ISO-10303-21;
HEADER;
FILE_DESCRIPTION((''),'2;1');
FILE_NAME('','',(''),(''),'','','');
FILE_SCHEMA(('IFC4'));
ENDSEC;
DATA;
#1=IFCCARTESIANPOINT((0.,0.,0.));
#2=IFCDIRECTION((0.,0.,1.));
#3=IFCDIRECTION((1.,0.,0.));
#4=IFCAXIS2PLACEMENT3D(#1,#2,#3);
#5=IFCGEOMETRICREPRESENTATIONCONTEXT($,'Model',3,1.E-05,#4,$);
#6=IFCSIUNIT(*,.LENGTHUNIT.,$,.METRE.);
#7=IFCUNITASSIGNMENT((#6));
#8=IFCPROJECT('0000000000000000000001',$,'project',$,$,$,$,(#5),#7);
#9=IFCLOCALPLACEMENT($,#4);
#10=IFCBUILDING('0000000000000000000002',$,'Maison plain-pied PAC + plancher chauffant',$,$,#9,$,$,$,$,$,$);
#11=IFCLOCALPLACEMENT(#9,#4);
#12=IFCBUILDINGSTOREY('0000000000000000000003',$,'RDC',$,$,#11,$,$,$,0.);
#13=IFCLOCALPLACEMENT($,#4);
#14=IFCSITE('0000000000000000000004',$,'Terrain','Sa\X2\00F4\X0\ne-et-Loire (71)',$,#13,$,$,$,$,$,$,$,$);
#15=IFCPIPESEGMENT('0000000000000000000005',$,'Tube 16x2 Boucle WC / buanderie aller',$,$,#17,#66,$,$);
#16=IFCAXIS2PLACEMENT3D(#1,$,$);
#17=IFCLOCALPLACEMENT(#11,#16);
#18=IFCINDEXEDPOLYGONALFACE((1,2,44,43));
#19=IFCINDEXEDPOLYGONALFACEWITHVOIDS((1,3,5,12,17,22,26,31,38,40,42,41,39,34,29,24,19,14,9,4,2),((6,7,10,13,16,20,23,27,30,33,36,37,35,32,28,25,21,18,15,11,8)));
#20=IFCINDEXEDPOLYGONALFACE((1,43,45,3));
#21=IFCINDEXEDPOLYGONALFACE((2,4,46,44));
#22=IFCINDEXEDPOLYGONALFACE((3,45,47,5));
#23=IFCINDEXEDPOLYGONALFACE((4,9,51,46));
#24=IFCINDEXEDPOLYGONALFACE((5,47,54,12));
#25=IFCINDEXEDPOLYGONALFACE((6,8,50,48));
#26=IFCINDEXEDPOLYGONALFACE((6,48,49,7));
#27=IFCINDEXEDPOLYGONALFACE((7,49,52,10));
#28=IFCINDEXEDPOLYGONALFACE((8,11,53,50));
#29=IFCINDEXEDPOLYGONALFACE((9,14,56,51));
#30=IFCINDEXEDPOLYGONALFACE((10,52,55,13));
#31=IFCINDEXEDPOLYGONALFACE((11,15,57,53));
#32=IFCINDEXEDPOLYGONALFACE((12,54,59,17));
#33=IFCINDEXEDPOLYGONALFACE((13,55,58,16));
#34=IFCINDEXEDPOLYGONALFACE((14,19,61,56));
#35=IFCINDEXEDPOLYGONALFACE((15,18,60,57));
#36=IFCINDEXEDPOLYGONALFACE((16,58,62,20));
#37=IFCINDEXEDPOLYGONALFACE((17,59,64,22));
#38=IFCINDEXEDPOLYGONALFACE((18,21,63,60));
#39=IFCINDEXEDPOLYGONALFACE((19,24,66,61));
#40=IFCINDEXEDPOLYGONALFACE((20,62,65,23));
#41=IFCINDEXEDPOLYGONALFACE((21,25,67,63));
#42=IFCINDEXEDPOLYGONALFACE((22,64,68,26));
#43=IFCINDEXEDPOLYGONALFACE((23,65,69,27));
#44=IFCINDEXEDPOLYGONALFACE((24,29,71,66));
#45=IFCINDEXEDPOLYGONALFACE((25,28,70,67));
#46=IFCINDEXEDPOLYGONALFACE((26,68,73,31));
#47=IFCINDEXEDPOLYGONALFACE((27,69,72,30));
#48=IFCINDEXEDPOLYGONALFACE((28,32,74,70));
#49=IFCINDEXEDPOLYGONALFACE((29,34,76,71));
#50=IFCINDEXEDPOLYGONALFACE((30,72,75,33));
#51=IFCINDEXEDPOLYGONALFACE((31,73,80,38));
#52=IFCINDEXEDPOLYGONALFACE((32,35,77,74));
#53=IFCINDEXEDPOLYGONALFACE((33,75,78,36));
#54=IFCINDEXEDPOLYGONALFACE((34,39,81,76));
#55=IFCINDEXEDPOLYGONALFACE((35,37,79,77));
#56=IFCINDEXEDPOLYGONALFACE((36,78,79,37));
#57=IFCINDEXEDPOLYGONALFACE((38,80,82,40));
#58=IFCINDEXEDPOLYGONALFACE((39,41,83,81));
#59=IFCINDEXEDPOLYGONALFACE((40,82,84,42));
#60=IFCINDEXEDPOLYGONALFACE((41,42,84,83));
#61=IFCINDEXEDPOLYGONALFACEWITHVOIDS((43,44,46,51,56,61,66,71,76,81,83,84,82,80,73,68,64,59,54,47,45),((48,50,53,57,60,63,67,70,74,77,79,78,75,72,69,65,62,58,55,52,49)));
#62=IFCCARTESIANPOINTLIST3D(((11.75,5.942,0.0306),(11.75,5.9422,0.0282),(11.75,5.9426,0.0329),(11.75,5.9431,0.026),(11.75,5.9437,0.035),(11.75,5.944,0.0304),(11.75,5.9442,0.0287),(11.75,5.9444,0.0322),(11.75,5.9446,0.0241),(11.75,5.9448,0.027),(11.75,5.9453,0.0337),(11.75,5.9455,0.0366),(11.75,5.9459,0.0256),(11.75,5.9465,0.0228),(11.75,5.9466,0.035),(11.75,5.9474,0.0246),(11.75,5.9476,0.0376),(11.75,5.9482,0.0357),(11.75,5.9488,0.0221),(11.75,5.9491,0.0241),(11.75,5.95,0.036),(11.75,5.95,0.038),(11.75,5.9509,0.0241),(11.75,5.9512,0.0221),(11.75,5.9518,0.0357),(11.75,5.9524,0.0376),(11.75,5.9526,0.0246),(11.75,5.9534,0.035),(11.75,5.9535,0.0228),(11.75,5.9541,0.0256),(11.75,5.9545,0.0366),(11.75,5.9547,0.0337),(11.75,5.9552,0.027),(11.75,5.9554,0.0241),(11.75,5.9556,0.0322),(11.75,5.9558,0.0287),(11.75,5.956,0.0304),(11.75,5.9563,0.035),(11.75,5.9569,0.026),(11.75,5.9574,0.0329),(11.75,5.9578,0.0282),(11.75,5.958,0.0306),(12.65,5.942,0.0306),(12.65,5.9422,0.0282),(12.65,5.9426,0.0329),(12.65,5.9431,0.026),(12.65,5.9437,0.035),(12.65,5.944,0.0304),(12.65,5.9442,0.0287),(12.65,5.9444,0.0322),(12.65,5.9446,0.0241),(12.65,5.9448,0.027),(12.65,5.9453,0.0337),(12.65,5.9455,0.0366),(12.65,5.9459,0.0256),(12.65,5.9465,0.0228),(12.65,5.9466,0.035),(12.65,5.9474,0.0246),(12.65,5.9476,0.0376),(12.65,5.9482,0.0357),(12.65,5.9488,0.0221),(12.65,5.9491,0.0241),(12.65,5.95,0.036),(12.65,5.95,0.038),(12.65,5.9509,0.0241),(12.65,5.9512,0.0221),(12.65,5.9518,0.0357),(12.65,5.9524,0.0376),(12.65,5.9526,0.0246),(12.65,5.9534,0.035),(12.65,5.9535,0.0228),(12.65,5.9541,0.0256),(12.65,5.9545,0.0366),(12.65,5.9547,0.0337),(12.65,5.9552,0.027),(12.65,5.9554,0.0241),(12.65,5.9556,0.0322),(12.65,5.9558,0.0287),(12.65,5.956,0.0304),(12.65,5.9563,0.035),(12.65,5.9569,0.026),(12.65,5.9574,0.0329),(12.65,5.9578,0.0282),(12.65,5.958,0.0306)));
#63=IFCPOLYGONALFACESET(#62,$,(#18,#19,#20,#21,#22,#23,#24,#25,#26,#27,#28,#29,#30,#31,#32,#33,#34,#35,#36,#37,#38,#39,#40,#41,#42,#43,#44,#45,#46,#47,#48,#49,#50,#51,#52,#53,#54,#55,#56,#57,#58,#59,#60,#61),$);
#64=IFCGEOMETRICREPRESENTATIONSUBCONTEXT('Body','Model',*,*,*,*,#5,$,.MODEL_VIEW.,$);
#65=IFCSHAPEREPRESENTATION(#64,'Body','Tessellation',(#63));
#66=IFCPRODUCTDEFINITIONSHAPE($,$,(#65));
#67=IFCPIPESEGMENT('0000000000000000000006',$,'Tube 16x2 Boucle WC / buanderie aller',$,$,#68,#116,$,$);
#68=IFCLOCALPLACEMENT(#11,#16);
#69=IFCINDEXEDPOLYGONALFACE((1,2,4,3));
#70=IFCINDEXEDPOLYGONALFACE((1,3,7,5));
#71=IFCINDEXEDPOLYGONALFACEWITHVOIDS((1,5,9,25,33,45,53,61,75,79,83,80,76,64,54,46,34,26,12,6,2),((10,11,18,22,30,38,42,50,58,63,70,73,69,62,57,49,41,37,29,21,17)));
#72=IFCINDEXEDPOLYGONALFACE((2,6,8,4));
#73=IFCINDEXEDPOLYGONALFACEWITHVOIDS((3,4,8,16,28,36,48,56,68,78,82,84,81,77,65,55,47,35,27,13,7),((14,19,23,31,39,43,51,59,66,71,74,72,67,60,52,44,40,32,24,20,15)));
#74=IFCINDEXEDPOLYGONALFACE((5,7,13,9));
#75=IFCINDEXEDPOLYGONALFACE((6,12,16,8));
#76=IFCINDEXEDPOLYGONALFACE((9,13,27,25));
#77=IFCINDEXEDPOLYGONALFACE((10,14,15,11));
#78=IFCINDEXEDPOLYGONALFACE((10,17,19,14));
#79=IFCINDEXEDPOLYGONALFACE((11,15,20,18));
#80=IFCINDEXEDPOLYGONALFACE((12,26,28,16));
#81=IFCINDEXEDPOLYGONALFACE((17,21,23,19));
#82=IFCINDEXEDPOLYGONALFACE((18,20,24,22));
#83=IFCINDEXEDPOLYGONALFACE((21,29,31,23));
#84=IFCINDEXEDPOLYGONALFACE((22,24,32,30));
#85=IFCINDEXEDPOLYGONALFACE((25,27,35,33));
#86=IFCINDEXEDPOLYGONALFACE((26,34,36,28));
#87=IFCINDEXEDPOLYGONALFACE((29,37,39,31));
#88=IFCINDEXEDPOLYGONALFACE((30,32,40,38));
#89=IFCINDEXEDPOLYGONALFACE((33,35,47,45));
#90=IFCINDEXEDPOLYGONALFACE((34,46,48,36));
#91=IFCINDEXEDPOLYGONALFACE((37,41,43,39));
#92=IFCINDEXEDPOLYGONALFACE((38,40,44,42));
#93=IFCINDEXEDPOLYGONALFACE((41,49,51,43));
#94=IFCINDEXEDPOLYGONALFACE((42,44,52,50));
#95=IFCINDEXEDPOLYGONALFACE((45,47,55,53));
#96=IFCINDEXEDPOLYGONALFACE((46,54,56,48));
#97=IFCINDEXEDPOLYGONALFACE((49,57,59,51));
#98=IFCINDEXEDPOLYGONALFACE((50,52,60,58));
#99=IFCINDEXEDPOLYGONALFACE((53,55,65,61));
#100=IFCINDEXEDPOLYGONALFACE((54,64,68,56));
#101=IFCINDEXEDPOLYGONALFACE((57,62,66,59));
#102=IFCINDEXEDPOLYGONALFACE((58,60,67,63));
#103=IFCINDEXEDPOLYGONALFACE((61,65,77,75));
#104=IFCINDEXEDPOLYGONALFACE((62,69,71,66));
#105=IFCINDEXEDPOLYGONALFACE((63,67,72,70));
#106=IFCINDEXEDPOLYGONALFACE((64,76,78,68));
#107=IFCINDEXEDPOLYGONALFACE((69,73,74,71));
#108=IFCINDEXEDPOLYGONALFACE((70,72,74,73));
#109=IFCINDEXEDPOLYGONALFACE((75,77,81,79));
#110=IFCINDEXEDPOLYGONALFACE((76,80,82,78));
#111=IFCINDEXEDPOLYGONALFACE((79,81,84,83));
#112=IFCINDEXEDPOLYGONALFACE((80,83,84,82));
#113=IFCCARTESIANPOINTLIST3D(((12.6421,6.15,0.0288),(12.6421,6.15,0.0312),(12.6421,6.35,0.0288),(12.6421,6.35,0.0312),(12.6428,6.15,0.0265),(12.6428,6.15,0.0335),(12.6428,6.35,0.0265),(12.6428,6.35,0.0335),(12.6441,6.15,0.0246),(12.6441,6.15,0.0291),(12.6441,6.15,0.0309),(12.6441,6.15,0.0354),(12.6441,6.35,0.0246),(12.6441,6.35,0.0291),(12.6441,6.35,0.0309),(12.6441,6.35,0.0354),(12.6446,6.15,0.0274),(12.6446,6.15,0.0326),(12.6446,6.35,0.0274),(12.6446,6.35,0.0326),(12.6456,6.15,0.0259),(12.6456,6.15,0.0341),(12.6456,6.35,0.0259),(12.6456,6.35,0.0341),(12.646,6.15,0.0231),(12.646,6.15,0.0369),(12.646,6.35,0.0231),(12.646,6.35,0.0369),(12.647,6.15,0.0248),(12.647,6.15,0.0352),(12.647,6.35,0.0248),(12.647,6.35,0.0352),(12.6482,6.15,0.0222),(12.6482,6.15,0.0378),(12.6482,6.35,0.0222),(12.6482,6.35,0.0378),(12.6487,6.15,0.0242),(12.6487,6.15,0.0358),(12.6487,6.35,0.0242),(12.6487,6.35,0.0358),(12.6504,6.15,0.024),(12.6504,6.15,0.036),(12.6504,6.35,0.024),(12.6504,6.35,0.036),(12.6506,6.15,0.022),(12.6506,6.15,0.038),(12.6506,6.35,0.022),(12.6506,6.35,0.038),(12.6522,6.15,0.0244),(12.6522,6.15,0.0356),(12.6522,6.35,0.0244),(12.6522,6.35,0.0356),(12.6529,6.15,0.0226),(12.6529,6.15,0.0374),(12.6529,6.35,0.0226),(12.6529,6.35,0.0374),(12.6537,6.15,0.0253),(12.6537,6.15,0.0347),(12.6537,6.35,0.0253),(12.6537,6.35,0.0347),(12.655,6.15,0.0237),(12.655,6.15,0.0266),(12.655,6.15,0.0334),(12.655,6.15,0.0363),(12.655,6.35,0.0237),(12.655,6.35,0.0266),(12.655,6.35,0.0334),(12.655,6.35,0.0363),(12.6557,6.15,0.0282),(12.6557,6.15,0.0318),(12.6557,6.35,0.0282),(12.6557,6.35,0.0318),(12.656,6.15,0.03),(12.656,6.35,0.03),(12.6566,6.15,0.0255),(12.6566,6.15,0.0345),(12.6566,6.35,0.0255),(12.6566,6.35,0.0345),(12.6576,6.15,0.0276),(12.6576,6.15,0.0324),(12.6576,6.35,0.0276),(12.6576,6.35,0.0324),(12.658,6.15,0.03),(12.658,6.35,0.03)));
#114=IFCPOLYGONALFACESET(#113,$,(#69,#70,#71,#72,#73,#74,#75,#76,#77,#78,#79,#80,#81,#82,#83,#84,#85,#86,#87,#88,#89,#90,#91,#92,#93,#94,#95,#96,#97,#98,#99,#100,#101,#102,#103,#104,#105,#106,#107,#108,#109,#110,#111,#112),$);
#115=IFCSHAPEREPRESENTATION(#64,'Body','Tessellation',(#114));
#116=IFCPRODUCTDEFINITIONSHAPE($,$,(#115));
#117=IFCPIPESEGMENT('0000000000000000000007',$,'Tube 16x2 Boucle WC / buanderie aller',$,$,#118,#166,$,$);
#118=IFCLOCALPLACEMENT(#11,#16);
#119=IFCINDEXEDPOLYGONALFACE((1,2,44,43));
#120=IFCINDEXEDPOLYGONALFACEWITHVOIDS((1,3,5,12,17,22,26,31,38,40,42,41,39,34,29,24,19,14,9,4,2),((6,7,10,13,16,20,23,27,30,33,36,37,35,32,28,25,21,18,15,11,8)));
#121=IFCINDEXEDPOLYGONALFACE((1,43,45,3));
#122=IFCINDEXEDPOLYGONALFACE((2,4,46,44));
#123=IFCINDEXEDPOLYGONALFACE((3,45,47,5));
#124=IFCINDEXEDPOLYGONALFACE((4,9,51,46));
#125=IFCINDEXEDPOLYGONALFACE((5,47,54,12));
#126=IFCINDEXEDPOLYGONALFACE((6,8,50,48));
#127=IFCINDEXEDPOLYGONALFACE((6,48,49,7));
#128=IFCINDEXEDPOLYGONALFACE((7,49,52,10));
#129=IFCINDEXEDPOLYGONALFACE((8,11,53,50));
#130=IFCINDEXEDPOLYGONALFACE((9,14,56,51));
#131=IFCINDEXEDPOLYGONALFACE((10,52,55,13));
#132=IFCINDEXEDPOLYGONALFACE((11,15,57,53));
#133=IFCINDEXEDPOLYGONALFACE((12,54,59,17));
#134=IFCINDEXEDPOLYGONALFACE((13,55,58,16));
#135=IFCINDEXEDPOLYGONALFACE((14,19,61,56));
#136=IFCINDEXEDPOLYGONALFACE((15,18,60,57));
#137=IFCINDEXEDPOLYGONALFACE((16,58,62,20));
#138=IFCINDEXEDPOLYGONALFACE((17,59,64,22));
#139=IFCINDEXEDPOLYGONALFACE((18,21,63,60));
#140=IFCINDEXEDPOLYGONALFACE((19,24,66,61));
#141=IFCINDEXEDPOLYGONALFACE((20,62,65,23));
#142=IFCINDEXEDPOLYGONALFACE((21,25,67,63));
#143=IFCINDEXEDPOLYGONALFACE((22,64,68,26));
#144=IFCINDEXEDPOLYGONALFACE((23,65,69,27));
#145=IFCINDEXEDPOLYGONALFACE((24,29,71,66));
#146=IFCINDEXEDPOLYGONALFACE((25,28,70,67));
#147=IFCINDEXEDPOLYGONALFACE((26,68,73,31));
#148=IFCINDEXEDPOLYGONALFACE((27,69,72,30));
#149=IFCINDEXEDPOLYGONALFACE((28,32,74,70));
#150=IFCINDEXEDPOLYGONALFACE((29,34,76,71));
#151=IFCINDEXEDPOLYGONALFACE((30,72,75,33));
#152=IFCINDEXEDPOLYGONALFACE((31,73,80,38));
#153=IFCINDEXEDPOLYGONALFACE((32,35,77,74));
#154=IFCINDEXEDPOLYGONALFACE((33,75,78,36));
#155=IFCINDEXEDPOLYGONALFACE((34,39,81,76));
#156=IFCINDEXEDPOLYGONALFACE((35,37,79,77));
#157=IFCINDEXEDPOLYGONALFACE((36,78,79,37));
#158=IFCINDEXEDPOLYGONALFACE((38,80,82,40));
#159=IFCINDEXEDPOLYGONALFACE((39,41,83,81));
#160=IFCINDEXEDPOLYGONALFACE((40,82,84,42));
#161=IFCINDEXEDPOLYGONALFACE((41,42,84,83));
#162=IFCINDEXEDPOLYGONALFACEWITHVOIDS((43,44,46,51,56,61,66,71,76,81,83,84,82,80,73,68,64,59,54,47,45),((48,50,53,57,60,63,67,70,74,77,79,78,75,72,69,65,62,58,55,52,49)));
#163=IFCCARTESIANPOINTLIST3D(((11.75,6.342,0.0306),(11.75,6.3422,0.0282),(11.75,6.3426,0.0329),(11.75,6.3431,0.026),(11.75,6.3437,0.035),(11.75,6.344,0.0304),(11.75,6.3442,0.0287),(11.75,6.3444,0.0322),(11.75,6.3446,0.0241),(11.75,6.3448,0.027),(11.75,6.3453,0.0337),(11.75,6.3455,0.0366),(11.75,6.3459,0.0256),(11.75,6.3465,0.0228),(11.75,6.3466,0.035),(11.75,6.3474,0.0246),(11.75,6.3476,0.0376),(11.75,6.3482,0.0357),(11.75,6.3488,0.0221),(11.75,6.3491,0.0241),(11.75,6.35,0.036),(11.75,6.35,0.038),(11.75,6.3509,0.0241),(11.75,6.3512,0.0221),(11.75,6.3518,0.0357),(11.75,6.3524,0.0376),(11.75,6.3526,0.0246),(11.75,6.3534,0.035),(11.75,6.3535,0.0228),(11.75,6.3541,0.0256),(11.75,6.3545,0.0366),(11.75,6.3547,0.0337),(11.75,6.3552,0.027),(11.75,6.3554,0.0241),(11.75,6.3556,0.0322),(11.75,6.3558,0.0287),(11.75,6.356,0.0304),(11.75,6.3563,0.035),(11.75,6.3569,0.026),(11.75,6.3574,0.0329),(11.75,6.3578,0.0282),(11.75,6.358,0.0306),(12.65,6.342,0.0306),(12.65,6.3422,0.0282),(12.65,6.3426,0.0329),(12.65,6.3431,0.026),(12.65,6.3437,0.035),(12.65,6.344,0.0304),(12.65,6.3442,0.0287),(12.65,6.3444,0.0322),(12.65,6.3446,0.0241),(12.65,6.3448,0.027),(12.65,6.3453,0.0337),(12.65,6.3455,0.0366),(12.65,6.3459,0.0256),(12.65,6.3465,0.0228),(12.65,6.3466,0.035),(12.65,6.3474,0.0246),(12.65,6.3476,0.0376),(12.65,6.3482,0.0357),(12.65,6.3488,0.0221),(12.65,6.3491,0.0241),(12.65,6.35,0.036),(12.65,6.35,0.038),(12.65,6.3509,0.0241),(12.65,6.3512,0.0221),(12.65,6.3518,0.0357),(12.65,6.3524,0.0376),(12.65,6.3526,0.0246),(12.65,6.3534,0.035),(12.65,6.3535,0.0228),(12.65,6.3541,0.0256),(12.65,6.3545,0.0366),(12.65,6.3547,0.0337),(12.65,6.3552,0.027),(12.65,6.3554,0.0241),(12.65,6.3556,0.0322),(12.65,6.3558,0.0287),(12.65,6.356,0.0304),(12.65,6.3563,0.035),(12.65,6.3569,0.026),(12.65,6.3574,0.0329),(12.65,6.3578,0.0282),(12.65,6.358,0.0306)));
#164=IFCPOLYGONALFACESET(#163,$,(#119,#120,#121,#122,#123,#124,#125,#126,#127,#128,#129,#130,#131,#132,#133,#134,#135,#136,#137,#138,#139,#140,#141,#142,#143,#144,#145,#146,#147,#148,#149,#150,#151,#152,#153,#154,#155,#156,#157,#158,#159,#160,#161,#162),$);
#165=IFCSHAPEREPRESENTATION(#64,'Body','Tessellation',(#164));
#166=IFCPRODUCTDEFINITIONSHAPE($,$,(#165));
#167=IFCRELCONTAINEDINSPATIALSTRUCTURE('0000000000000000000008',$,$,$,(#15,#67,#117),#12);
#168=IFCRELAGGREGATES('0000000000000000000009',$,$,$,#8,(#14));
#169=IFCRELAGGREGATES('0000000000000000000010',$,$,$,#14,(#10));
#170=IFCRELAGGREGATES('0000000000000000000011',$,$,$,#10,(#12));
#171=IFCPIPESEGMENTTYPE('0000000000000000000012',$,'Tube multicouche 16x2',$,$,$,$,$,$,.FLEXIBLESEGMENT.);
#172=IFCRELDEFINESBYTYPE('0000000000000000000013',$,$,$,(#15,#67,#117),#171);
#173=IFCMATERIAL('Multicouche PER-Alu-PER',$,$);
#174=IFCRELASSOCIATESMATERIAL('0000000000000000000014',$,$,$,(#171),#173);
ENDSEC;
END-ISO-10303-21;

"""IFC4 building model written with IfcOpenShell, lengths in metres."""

from ifc_helpers import new_model, si_unit, frame, origin_with_axes, place, context, subcontext, project, spatial, hollow_circle, extrude, material, type_object, element, save


model = new_model("IFC4")

# Units and contexts
model_context = context("Model", 3, precision=1e-05, world=origin_with_axes())
body_context = subcontext(model_context, "Body", "Model", "MODEL_VIEW")
ifc_project = project(units=[si_unit("LENGTHUNIT", "METRE")], contexts=[model_context])

# Site, building, storey
site_placement = place(None, origin_with_axes())
site = spatial("IfcSite", under=ifc_project, at=site_placement, Name="Terrain", Description="Saône-et-Loire (71)")
building_placement = place(None, origin_with_axes())
building = spatial("IfcBuilding", under=site, at=building_placement, Name="Maison plain-pied PAC + plancher chauffant")
storey_placement = place(building_placement, origin_with_axes())
storey = spatial("IfcBuildingStorey", under=building, at=storey_placement, Name="RDC", Elevation=0.0)

# Pipe segments
ifc_material_1 = material(Name="Multicouche PER-Alu-PER")
pipe_segment_type_1 = type_object("IfcPipeSegmentType", Name="Tube multicouche 16x2", PredefinedType="FLEXIBLESEGMENT", material=ifc_material_1)
pipe_segment_1_placement = place(storey_placement, frame((12.65, 5.95, 0.03), z_axis=(-1.0, 0.0, 0.0), x_axis=(0.0, 0.0, 1.0)))
element("IfcPipeSegment", 1, at=pipe_segment_1_placement, inside=storey, type_object=pipe_segment_type_1, Name="Tube 16x2 Boucle WC / buanderie aller", context=body_context, shape_type="SweptSolid", body=[
    extrude(hollow_circle(Radius=0.008, WallThickness=0.002), origin_with_axes(), (0.0, 0.0, 1.0), 0.9),
])
pipe_segment_2_placement = place(storey_placement, frame((12.65, 6.15, 0.03), z_axis=(0.0, 1.0, 0.0), x_axis=(1.0, 0.0, 0.0)))
element("IfcPipeSegment", 2, at=pipe_segment_2_placement, inside=storey, type_object=pipe_segment_type_1, Name="Tube 16x2 Boucle WC / buanderie aller", context=body_context, shape_type="SweptSolid", body=[
    extrude(hollow_circle(Radius=0.008, WallThickness=0.002), origin_with_axes(), (0.0, 0.0, 1.0), 0.2),
])
pipe_segment_3_placement = place(storey_placement, frame((12.65, 6.35, 0.03), z_axis=(-1.0, 0.0, 0.0), x_axis=(0.0, 0.0, 1.0)))
element("IfcPipeSegment", 3, at=pipe_segment_3_placement, inside=storey, type_object=pipe_segment_type_1, Name="Tube 16x2 Boucle WC / buanderie aller", context=body_context, shape_type="SweptSolid", body=[
    extrude(hollow_circle(Radius=0.008, WallThickness=0.002), origin_with_axes(), (0.0, 0.0, 1.0), 0.9),
])

save(model, "model.ifc")
